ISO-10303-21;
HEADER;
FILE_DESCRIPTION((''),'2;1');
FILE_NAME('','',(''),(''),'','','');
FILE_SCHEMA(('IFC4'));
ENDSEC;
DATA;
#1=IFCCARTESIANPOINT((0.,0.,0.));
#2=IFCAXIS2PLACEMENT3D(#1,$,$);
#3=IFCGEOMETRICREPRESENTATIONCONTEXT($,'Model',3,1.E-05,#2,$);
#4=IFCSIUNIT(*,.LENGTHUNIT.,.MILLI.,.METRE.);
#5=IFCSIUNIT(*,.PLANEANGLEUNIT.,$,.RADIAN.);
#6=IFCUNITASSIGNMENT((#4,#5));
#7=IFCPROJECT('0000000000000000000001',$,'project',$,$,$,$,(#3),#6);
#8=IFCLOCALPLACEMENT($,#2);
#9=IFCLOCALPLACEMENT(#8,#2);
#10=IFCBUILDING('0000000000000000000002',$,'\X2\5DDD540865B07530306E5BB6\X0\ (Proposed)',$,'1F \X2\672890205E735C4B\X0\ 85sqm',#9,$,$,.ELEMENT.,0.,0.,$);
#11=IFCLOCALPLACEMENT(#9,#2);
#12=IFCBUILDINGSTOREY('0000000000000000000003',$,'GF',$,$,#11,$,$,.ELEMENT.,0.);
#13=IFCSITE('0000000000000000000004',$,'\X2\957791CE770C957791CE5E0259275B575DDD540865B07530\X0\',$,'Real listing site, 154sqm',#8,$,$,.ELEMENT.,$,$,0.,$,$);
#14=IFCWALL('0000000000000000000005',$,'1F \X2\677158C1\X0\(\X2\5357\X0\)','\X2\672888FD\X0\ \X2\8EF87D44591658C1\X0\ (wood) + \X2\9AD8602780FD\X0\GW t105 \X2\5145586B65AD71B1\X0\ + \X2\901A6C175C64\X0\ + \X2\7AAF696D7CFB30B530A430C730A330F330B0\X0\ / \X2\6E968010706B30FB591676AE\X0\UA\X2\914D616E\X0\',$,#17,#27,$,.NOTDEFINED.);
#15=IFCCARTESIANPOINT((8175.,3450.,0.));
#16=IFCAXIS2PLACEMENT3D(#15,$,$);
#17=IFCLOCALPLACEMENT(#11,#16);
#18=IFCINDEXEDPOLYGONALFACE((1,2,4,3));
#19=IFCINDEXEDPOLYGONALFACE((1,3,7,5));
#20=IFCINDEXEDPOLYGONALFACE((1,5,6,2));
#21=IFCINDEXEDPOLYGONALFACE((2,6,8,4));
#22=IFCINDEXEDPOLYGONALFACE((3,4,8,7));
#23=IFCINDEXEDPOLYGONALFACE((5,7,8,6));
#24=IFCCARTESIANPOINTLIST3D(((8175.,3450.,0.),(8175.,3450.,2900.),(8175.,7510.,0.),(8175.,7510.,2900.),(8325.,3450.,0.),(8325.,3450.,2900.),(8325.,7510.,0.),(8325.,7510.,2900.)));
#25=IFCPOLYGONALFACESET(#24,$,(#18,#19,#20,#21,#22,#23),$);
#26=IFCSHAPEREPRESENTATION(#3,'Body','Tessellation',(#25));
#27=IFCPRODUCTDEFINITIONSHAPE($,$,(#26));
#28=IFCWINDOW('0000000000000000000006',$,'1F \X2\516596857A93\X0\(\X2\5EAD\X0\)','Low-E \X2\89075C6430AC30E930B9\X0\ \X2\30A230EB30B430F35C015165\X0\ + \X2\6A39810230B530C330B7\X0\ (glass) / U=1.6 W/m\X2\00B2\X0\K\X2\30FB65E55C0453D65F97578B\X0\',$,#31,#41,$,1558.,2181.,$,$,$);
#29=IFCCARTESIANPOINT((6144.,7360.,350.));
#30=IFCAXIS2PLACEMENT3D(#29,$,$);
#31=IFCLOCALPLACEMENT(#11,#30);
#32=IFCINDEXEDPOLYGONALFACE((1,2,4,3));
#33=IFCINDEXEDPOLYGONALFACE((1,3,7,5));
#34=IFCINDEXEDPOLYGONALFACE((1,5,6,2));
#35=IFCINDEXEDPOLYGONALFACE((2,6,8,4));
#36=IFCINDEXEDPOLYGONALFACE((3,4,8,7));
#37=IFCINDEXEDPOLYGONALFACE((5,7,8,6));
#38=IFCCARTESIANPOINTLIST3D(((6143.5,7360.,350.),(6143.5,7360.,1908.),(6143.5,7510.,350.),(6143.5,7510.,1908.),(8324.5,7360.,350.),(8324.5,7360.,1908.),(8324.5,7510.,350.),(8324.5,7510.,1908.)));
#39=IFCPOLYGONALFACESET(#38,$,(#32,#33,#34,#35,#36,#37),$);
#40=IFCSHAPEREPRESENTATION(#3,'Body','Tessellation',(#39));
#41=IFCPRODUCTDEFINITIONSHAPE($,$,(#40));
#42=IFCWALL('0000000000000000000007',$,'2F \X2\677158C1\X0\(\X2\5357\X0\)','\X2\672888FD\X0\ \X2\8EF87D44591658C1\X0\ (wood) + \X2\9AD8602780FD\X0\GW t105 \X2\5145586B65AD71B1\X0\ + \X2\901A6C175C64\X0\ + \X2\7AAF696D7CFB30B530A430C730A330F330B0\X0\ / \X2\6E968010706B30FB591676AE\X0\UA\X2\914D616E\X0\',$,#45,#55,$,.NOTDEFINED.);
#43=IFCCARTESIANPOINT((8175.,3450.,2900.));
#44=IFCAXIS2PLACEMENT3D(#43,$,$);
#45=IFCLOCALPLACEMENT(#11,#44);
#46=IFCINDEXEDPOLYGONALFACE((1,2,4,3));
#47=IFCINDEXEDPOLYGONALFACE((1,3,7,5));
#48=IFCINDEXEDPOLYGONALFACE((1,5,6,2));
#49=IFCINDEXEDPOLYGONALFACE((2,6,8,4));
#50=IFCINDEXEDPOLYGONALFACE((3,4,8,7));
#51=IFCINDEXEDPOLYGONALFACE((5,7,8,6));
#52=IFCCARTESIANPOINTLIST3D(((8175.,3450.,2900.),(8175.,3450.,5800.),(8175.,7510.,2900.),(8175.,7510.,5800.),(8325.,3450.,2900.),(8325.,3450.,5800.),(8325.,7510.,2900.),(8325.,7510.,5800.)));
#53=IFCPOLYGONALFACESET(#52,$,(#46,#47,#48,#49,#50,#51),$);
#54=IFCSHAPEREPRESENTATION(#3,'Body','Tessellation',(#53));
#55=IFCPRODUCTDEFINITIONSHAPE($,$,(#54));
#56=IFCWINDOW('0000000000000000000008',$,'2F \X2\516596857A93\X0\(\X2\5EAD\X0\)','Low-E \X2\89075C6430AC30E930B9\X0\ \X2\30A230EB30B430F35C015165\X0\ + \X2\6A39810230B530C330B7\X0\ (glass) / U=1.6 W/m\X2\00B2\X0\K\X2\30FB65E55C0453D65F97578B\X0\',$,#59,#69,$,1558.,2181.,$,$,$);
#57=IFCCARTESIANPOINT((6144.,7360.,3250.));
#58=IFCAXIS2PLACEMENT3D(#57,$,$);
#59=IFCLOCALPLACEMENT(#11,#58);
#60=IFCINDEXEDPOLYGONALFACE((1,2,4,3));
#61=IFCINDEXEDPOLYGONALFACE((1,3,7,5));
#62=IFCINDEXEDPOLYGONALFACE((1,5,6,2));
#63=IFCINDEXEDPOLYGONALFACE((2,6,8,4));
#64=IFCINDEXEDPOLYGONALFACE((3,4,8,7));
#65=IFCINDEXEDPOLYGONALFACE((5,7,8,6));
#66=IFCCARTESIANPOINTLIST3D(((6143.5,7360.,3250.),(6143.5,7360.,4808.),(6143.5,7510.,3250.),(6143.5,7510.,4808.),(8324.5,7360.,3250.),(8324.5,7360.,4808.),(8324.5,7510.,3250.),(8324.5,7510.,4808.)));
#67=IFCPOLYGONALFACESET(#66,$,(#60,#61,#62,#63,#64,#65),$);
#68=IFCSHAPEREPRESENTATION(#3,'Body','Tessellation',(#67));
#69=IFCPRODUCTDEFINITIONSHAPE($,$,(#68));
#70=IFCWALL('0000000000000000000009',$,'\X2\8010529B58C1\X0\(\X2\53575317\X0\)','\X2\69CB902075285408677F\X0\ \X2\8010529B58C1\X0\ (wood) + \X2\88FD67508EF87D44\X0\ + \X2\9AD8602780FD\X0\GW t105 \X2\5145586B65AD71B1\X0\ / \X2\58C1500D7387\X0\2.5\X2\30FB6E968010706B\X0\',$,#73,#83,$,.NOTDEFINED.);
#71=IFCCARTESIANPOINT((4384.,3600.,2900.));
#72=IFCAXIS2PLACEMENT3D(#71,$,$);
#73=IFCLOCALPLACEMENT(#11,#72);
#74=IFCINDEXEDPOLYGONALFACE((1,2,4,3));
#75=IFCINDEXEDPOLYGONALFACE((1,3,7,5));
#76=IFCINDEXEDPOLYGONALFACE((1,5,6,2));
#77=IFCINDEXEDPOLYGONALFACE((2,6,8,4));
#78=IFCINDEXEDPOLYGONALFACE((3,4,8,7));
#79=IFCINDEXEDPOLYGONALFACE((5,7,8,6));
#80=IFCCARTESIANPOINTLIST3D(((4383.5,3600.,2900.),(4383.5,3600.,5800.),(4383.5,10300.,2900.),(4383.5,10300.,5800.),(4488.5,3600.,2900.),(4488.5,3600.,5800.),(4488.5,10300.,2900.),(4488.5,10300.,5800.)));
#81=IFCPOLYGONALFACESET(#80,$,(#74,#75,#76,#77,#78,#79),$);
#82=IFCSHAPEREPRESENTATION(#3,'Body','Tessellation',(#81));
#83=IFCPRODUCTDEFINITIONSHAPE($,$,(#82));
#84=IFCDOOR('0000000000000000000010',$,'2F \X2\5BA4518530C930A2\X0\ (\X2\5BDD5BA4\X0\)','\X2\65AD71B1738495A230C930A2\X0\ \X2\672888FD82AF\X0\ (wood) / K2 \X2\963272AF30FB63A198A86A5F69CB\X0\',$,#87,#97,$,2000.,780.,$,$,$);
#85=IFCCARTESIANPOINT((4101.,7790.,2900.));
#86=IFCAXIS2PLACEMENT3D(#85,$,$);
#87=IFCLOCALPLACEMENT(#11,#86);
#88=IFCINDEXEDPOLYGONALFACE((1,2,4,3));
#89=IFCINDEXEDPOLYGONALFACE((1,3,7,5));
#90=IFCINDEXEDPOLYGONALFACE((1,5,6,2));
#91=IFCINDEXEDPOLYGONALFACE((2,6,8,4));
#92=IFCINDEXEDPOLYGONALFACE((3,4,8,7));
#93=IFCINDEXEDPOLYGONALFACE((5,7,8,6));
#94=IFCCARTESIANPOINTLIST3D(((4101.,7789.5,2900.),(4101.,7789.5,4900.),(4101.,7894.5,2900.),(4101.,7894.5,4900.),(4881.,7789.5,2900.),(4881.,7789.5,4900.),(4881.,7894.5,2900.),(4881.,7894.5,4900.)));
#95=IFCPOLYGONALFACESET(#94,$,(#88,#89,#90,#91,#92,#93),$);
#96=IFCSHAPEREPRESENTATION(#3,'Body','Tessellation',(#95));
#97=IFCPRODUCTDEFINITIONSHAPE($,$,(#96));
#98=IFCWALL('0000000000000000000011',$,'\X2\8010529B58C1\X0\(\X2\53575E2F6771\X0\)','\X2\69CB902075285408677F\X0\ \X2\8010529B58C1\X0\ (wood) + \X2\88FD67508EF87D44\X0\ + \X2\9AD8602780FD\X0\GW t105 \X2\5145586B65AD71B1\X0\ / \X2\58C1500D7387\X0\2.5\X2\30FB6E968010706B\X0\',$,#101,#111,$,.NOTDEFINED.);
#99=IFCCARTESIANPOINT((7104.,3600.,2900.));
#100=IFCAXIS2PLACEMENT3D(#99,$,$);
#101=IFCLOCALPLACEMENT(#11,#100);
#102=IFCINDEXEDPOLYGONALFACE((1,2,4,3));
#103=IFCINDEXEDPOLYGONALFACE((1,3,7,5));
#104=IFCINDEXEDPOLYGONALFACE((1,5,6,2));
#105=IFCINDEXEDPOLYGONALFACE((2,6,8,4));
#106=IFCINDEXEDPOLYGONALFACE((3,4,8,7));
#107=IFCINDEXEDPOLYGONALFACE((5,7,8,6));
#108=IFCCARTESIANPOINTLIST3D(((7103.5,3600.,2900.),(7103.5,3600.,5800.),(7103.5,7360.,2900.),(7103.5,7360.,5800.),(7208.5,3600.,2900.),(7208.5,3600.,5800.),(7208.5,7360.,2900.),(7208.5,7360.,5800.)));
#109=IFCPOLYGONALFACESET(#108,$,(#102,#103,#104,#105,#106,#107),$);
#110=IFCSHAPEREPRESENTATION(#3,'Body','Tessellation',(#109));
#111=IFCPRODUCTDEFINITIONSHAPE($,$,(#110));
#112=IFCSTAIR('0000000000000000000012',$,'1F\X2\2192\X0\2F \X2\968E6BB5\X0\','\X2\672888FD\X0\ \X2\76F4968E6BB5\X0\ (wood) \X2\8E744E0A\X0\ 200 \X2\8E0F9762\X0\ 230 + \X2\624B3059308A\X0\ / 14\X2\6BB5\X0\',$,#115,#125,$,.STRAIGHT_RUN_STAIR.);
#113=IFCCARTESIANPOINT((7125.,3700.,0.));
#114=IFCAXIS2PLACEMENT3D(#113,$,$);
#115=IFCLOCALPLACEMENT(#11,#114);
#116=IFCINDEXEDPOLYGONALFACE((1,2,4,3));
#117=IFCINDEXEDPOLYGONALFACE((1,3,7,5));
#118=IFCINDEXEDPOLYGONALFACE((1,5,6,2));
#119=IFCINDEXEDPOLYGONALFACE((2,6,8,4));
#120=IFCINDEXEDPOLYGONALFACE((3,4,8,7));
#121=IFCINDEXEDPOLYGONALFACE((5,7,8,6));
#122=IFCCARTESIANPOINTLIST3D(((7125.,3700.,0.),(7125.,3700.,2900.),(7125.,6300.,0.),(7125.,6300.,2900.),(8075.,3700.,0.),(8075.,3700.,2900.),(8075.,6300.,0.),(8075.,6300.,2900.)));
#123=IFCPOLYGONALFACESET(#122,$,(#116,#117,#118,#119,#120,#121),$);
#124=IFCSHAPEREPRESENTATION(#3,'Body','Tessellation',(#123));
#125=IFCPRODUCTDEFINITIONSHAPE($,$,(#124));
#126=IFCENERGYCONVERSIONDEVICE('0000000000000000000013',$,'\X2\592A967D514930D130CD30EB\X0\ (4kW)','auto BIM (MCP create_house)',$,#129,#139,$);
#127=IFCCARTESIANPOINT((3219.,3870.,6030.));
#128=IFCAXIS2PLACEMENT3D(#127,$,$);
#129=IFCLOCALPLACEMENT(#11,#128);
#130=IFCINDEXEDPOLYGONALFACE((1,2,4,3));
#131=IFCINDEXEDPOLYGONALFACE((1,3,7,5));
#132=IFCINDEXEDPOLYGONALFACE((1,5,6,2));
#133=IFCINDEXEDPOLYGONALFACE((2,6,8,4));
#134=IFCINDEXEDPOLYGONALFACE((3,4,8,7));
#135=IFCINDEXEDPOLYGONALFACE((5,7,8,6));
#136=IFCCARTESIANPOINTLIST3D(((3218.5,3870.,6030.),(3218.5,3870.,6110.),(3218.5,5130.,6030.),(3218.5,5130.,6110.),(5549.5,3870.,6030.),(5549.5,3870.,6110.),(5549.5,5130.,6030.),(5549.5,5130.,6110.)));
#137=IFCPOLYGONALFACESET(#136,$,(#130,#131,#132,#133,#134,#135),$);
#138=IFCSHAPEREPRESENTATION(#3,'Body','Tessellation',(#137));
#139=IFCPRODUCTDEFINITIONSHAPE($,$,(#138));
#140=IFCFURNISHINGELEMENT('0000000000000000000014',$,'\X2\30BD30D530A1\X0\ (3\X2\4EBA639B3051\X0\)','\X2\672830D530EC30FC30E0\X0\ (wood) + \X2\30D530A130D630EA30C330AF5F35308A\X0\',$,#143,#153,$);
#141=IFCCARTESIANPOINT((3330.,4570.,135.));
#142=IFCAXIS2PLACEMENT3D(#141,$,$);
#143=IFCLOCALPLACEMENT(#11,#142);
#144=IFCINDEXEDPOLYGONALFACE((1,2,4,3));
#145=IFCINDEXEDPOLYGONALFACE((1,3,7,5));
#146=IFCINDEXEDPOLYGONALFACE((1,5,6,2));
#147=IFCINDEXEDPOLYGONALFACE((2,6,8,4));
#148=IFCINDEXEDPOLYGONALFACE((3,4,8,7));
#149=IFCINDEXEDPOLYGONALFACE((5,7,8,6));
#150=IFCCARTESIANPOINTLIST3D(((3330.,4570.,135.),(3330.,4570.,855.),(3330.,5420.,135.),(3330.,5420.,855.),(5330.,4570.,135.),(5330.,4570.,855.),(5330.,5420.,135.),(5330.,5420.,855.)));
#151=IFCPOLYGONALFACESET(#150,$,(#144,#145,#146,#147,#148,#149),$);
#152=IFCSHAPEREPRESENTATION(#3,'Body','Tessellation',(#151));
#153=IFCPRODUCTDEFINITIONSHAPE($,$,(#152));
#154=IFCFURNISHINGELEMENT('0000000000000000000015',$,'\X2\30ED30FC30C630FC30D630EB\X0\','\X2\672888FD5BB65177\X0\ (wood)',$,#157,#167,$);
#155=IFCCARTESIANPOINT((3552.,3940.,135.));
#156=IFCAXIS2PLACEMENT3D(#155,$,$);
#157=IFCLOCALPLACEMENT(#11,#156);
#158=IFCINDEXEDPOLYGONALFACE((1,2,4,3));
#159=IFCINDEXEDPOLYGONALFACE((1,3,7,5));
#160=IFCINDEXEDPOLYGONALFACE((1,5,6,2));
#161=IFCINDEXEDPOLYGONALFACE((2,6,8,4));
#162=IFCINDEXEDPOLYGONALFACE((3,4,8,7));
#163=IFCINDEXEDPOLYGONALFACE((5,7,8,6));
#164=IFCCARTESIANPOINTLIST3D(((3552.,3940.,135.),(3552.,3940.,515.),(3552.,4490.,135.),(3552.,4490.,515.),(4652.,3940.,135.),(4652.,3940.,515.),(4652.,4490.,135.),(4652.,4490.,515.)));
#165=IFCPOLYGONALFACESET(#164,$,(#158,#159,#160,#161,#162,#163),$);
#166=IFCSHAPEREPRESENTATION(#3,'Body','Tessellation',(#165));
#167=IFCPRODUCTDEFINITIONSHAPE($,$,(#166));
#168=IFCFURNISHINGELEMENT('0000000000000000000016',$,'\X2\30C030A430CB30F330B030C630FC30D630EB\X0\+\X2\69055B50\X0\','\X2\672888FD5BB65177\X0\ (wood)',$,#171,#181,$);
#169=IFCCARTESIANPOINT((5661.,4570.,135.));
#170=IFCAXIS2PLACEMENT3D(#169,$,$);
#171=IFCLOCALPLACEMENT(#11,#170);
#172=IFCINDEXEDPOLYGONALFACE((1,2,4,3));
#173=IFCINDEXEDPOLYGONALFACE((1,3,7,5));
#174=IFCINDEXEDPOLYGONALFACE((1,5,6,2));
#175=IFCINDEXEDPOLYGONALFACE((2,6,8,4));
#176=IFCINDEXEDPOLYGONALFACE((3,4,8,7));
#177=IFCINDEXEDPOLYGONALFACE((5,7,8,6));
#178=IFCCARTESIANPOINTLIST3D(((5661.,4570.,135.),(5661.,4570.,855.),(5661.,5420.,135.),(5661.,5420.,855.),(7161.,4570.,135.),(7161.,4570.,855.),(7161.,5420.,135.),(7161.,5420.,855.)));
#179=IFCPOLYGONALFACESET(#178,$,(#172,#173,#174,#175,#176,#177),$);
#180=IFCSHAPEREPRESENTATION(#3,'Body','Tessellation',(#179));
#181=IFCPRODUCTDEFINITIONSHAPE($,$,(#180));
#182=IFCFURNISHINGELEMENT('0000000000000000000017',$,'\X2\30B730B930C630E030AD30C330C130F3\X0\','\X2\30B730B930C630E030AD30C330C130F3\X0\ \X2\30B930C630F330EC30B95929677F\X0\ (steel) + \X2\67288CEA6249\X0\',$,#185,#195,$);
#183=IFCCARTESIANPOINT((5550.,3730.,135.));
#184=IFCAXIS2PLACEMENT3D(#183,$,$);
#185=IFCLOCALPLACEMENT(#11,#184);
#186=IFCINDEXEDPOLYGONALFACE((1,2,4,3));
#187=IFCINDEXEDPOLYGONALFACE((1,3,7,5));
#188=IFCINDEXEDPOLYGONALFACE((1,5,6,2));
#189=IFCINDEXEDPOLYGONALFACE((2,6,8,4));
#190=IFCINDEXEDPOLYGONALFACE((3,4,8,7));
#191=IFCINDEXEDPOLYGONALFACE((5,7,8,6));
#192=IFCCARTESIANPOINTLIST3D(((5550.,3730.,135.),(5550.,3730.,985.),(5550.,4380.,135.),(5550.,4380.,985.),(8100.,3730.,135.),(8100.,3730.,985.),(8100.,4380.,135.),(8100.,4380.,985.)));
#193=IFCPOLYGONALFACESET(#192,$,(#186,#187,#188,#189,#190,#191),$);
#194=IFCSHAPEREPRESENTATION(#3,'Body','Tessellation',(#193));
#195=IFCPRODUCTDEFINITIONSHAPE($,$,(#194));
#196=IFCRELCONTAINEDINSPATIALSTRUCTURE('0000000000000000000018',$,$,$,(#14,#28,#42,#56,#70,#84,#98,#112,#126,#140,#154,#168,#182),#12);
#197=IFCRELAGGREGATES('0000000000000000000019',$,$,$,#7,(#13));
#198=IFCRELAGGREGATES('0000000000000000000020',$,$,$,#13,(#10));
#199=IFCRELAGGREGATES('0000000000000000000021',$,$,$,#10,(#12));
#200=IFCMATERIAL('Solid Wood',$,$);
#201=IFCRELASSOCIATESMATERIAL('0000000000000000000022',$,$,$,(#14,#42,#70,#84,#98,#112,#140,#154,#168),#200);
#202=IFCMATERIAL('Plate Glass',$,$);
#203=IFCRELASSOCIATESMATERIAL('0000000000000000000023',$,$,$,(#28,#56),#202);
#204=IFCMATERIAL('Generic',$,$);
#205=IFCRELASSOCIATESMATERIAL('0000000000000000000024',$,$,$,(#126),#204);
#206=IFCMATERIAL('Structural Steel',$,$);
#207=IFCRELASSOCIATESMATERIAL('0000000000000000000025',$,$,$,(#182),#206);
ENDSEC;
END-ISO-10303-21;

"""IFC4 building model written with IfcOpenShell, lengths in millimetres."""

from ifc_helpers import new_model, si_unit, frame, frame_2d, origin, place, context, project, spatial, rectangle, extrude, material, element, fill, save


model = new_model("IFC4")

# Units and contexts
model_context = context("Model", 3, precision=1e-05, world=origin())
ifc_project = project(units=[si_unit("LENGTHUNIT", "METRE", prefix="MILLI"), si_unit("PLANEANGLEUNIT", "RADIAN")], contexts=[model_context])

# Site, building, storey
site_placement = place(None, origin())
site = spatial("IfcSite", under=ifc_project, at=site_placement, Name="長野県長野市大字川合新田", ObjectType="Real listing site, 154sqm", CompositionType="ELEMENT", RefElevation=0.0)
building_placement = place(site_placement, origin())
building = spatial("IfcBuilding", under=site, at=building_placement, Name="川合新田の家 (Proposed)", ObjectType="1F 木造平屋 85sqm", CompositionType="ELEMENT", ElevationOfRefHeight=0.0, ElevationOfTerrain=0.0)
storey_placement = place(building_placement, origin())
storey = spatial("IfcBuildingStorey", under=building, at=storey_placement, Name="GF", CompositionType="ELEMENT", Elevation=0.0)

# Wall, opening, window
ifc_material_1 = material(Name="Solid Wood")
wall_1_placement = place(storey_placement, frame((8175.0, 3450.0, 0.0)))
wall_1 = element("IfcWall", 1, at=wall_1_placement, inside=storey, material=ifc_material_1, Name="1F 東壁(南)", Description="木製 軸組外壁 (wood) + 高性能GW t105 充填断熱 + 通気層 + 窯業系サイディング / 準耐火・外皮UA配慮", PredefinedType="NOTDEFINED", context=model_context, shape_type="SweptSolid", body=[
    extrude(rectangle(XDim=150.0, YDim=4060.0, at=frame_2d((75.0, 2030.0))), frame((8175.0, 3450.0, 0.0)), (0.0, 0.0, 1.0), 2900.0),
])
opening_1_placement = place(storey_placement, frame((6144.0, 7360.0, 350.0)))
opening_1 = element("IfcOpeningElement", 2, at=opening_1_placement, cuts=wall_1, PredefinedType="NOTDEFINED", context=model_context, shape_type="SweptSolid", body=[
    extrude(rectangle(XDim=2181.0, YDim=150.0, at=frame_2d((1090.0, 75.0))), frame((6144.0, 7360.0, 350.0)), (0.0, 0.0, 1.0), 1558.0),
])
ifc_material_2 = material(Name="Plate Glass")
window_1_placement = place(storey_placement, frame((6144.0, 7360.0, 350.0)))
window_1 = element("IfcWindow", 3, at=window_1_placement, inside=storey, material=ifc_material_2, Name="1F 入隅窓(庭)", Description="Low-E 複層ガラス アルゴン封入 + 樹脂サッシ (glass) / U=1.6 W/m²K・日射取得型", OverallHeight=1558.0, OverallWidth=2181.0, context=model_context, shape_type="SweptSolid", body=[
    extrude(rectangle(XDim=2181.0, YDim=150.0, at=frame_2d((1090.0, 75.0))), frame((6144.0, 7360.0, 350.0)), (0.0, 0.0, 1.0), 1558.0),
])
fill(opening_1, window_1)

# Wall, opening, window
wall_2_placement = place(storey_placement, frame((8175.0, 3450.0, 2900.0)))
wall_2 = element("IfcWall", 4, at=wall_2_placement, inside=storey, material=ifc_material_1, Name="2F 東壁(南)", Description="木製 軸組外壁 (wood) + 高性能GW t105 充填断熱 + 通気層 + 窯業系サイディング / 準耐火・外皮UA配慮", PredefinedType="NOTDEFINED", context=model_context, shape_type="SweptSolid", body=[
    extrude(rectangle(XDim=150.0, YDim=4060.0, at=frame_2d((75.0, 2030.0))), frame((8175.0, 3450.0, 2900.0)), (0.0, 0.0, 1.0), 2900.0),
])
opening_2_placement = place(storey_placement, frame((6144.0, 7360.0, 3250.0)))
opening_2 = element("IfcOpeningElement", 5, at=opening_2_placement, cuts=wall_2, PredefinedType="NOTDEFINED", context=model_context, shape_type="SweptSolid", body=[
    extrude(rectangle(XDim=2181.0, YDim=150.0, at=frame_2d((1090.0, 75.0))), frame((6144.0, 7360.0, 3250.0)), (0.0, 0.0, 1.0), 1558.0),
])
window_2_placement = place(storey_placement, frame((6144.0, 7360.0, 3250.0)))
window_2 = element("IfcWindow", 6, at=window_2_placement, inside=storey, material=ifc_material_2, Name="2F 入隅窓(庭)", Description="Low-E 複層ガラス アルゴン封入 + 樹脂サッシ (glass) / U=1.6 W/m²K・日射取得型", OverallHeight=1558.0, OverallWidth=2181.0, context=model_context, shape_type="SweptSolid", body=[
    extrude(rectangle(XDim=2181.0, YDim=150.0, at=frame_2d((1090.0, 75.0))), frame((6144.0, 7360.0, 3250.0)), (0.0, 0.0, 1.0), 1558.0),
])
fill(opening_2, window_2)

# Wall, opening, door
wall_3_placement = place(storey_placement, frame((4384.0, 3600.0, 2900.0)))
wall_3 = element("IfcWall", 7, at=wall_3_placement, inside=storey, material=ifc_material_1, Name="耐力壁(南北)", Description="構造用合板 耐力壁 (wood) + 製材軸組 + 高性能GW t105 充填断熱 / 壁倍率2.5・準耐火", PredefinedType="NOTDEFINED", context=model_context, shape_type="SweptSolid", body=[
    extrude(rectangle(XDim=105.0, YDim=6700.0, at=frame_2d((52.0, 3350.0))), frame((4384.0, 3600.0, 2900.0)), (0.0, 0.0, 1.0), 2900.0),
])
opening_3_placement = place(storey_placement, frame((4101.0, 7790.0, 2900.0)))
opening_3 = element("IfcOpeningElement", 8, at=opening_3_placement, cuts=wall_3, PredefinedType="NOTDEFINED", context=model_context, shape_type="SweptSolid", body=[
    extrude(rectangle(XDim=780.0, YDim=105.0, at=frame_2d((390.0, 52.0))), frame((4101.0, 7790.0, 2900.0)), (0.0, 0.0, 1.0), 2000.0),
])
door_1_placement = place(storey_placement, frame((4101.0, 7790.0, 2900.0)))
door_1 = element("IfcDoor", 9, at=door_1_placement, inside=storey, material=ifc_material_1, Name="2F 室内ドア (寝室)", Description="断熱玄関ドア 木製芯 (wood) / K2 防犯・採風機構", OverallHeight=2000.0, OverallWidth=780.0, context=model_context, shape_type="SweptSolid", body=[
    extrude(rectangle(XDim=780.0, YDim=105.0, at=frame_2d((390.0, 52.0))), frame((4101.0, 7790.0, 2900.0)), (0.0, 0.0, 1.0), 2000.0),
])
fill(opening_3, door_1)

# Wall
wall_4_placement = place(storey_placement, frame((7104.0, 3600.0, 2900.0)))
element("IfcWall", 10, at=wall_4_placement, inside=storey, material=ifc_material_1, Name="耐力壁(南帯東)", Description="構造用合板 耐力壁 (wood) + 製材軸組 + 高性能GW t105 充填断熱 / 壁倍率2.5・準耐火", PredefinedType="NOTDEFINED", context=model_context, shape_type="SweptSolid", body=[
    extrude(rectangle(XDim=105.0, YDim=3760.0, at=frame_2d((52.0, 1880.0))), frame((7104.0, 3600.0, 2900.0)), (0.0, 0.0, 1.0), 2900.0),
])

# Stair
stair_placement = place(storey_placement, frame((7125.0, 3700.0, 0.0)))
element("IfcStair", 11, at=stair_placement, inside=storey, material=ifc_material_1, Name="1F→2F 階段", Description="木製 直階段 (wood) 蹴上 200 踏面 230 + 手すり / 14段", PredefinedType="STRAIGHT_RUN_STAIR", context=model_context, shape_type="SweptSolid", body=[
    extrude(rectangle(XDim=950.0, YDim=2600.0, at=frame_2d((475.0, 1300.0))), frame((7125.0, 3700.0, 0.0)), (0.0, 0.0, 1.0), 2900.0),
])

# Energy conversion device
ifc_material_3 = material(Name="Generic")
energy_conversion_device_placement = place(storey_placement, frame((3219.0, 3870.0, 6030.0)))
element("IfcEnergyConversionDevice", 12, at=energy_conversion_device_placement, inside=storey, material=ifc_material_3, Name="太陽光パネル (4kW)", Description="auto BIM (MCP create_house)", context=model_context, shape_type="SweptSolid", body=[
    extrude(rectangle(XDim=2331.0, YDim=1260.0, at=frame_2d((1165.0, 630.0))), frame((3219.0, 3870.0, 6030.0)), (0.0, 0.0, 1.0), 80.0),
])

# Furnishing elements
furnishing_1_placement = place(storey_placement, frame((3330.0, 4570.0, 135.0)))
element("IfcFurnishingElement", 13, at=furnishing_1_placement, inside=storey, material=ifc_material_1, Name="ソファ (3人掛け)", Description="木フレーム (wood) + ファブリック張り", context=model_context, shape_type="SweptSolid", body=[
    extrude(rectangle(XDim=2000.0, YDim=850.0, at=frame_2d((1000.0, 425.0))), frame((3330.0, 4570.0, 135.0)), (0.0, 0.0, 1.0), 720.0),
])
furnishing_2_placement = place(storey_placement, frame((3552.0, 3940.0, 135.0)))
element("IfcFurnishingElement", 14, at=furnishing_2_placement, inside=storey, material=ifc_material_1, Name="ローテーブル", Description="木製家具 (wood)", context=model_context, shape_type="SweptSolid", body=[
    extrude(rectangle(XDim=1100.0, YDim=550.0, at=frame_2d((550.0, 275.0))), frame((3552.0, 3940.0, 135.0)), (0.0, 0.0, 1.0), 380.0),
])
furnishing_3_placement = place(storey_placement, frame((5661.0, 4570.0, 135.0)))
element("IfcFurnishingElement", 15, at=furnishing_3_placement, inside=storey, material=ifc_material_1, Name="ダイニングテーブル+椅子", Description="木製家具 (wood)", context=model_context, shape_type="SweptSolid", body=[
    extrude(rectangle(XDim=1500.0, YDim=850.0, at=frame_2d((750.0, 425.0))), frame((5661.0, 4570.0, 135.0)), (0.0, 0.0, 1.0), 720.0),
])
ifc_material_4 = material(Name="Structural Steel")
furnishing_4_placement = place(storey_placement, frame((5550.0, 3730.0, 135.0)))
element("IfcFurnishingElement", 16, at=furnishing_4_placement, inside=storey, material=ifc_material_4, Name="システムキッチン", Description="システムキッチン ステンレス天板 (steel) + 木質扉", context=model_context, shape_type="SweptSolid", body=[
    extrude(rectangle(XDim=2550.0, YDim=650.0, at=frame_2d((1275.0, 325.0))), frame((5550.0, 3730.0, 135.0)), (0.0, 0.0, 1.0), 850.0),
])

save(model, "model.ifc")
